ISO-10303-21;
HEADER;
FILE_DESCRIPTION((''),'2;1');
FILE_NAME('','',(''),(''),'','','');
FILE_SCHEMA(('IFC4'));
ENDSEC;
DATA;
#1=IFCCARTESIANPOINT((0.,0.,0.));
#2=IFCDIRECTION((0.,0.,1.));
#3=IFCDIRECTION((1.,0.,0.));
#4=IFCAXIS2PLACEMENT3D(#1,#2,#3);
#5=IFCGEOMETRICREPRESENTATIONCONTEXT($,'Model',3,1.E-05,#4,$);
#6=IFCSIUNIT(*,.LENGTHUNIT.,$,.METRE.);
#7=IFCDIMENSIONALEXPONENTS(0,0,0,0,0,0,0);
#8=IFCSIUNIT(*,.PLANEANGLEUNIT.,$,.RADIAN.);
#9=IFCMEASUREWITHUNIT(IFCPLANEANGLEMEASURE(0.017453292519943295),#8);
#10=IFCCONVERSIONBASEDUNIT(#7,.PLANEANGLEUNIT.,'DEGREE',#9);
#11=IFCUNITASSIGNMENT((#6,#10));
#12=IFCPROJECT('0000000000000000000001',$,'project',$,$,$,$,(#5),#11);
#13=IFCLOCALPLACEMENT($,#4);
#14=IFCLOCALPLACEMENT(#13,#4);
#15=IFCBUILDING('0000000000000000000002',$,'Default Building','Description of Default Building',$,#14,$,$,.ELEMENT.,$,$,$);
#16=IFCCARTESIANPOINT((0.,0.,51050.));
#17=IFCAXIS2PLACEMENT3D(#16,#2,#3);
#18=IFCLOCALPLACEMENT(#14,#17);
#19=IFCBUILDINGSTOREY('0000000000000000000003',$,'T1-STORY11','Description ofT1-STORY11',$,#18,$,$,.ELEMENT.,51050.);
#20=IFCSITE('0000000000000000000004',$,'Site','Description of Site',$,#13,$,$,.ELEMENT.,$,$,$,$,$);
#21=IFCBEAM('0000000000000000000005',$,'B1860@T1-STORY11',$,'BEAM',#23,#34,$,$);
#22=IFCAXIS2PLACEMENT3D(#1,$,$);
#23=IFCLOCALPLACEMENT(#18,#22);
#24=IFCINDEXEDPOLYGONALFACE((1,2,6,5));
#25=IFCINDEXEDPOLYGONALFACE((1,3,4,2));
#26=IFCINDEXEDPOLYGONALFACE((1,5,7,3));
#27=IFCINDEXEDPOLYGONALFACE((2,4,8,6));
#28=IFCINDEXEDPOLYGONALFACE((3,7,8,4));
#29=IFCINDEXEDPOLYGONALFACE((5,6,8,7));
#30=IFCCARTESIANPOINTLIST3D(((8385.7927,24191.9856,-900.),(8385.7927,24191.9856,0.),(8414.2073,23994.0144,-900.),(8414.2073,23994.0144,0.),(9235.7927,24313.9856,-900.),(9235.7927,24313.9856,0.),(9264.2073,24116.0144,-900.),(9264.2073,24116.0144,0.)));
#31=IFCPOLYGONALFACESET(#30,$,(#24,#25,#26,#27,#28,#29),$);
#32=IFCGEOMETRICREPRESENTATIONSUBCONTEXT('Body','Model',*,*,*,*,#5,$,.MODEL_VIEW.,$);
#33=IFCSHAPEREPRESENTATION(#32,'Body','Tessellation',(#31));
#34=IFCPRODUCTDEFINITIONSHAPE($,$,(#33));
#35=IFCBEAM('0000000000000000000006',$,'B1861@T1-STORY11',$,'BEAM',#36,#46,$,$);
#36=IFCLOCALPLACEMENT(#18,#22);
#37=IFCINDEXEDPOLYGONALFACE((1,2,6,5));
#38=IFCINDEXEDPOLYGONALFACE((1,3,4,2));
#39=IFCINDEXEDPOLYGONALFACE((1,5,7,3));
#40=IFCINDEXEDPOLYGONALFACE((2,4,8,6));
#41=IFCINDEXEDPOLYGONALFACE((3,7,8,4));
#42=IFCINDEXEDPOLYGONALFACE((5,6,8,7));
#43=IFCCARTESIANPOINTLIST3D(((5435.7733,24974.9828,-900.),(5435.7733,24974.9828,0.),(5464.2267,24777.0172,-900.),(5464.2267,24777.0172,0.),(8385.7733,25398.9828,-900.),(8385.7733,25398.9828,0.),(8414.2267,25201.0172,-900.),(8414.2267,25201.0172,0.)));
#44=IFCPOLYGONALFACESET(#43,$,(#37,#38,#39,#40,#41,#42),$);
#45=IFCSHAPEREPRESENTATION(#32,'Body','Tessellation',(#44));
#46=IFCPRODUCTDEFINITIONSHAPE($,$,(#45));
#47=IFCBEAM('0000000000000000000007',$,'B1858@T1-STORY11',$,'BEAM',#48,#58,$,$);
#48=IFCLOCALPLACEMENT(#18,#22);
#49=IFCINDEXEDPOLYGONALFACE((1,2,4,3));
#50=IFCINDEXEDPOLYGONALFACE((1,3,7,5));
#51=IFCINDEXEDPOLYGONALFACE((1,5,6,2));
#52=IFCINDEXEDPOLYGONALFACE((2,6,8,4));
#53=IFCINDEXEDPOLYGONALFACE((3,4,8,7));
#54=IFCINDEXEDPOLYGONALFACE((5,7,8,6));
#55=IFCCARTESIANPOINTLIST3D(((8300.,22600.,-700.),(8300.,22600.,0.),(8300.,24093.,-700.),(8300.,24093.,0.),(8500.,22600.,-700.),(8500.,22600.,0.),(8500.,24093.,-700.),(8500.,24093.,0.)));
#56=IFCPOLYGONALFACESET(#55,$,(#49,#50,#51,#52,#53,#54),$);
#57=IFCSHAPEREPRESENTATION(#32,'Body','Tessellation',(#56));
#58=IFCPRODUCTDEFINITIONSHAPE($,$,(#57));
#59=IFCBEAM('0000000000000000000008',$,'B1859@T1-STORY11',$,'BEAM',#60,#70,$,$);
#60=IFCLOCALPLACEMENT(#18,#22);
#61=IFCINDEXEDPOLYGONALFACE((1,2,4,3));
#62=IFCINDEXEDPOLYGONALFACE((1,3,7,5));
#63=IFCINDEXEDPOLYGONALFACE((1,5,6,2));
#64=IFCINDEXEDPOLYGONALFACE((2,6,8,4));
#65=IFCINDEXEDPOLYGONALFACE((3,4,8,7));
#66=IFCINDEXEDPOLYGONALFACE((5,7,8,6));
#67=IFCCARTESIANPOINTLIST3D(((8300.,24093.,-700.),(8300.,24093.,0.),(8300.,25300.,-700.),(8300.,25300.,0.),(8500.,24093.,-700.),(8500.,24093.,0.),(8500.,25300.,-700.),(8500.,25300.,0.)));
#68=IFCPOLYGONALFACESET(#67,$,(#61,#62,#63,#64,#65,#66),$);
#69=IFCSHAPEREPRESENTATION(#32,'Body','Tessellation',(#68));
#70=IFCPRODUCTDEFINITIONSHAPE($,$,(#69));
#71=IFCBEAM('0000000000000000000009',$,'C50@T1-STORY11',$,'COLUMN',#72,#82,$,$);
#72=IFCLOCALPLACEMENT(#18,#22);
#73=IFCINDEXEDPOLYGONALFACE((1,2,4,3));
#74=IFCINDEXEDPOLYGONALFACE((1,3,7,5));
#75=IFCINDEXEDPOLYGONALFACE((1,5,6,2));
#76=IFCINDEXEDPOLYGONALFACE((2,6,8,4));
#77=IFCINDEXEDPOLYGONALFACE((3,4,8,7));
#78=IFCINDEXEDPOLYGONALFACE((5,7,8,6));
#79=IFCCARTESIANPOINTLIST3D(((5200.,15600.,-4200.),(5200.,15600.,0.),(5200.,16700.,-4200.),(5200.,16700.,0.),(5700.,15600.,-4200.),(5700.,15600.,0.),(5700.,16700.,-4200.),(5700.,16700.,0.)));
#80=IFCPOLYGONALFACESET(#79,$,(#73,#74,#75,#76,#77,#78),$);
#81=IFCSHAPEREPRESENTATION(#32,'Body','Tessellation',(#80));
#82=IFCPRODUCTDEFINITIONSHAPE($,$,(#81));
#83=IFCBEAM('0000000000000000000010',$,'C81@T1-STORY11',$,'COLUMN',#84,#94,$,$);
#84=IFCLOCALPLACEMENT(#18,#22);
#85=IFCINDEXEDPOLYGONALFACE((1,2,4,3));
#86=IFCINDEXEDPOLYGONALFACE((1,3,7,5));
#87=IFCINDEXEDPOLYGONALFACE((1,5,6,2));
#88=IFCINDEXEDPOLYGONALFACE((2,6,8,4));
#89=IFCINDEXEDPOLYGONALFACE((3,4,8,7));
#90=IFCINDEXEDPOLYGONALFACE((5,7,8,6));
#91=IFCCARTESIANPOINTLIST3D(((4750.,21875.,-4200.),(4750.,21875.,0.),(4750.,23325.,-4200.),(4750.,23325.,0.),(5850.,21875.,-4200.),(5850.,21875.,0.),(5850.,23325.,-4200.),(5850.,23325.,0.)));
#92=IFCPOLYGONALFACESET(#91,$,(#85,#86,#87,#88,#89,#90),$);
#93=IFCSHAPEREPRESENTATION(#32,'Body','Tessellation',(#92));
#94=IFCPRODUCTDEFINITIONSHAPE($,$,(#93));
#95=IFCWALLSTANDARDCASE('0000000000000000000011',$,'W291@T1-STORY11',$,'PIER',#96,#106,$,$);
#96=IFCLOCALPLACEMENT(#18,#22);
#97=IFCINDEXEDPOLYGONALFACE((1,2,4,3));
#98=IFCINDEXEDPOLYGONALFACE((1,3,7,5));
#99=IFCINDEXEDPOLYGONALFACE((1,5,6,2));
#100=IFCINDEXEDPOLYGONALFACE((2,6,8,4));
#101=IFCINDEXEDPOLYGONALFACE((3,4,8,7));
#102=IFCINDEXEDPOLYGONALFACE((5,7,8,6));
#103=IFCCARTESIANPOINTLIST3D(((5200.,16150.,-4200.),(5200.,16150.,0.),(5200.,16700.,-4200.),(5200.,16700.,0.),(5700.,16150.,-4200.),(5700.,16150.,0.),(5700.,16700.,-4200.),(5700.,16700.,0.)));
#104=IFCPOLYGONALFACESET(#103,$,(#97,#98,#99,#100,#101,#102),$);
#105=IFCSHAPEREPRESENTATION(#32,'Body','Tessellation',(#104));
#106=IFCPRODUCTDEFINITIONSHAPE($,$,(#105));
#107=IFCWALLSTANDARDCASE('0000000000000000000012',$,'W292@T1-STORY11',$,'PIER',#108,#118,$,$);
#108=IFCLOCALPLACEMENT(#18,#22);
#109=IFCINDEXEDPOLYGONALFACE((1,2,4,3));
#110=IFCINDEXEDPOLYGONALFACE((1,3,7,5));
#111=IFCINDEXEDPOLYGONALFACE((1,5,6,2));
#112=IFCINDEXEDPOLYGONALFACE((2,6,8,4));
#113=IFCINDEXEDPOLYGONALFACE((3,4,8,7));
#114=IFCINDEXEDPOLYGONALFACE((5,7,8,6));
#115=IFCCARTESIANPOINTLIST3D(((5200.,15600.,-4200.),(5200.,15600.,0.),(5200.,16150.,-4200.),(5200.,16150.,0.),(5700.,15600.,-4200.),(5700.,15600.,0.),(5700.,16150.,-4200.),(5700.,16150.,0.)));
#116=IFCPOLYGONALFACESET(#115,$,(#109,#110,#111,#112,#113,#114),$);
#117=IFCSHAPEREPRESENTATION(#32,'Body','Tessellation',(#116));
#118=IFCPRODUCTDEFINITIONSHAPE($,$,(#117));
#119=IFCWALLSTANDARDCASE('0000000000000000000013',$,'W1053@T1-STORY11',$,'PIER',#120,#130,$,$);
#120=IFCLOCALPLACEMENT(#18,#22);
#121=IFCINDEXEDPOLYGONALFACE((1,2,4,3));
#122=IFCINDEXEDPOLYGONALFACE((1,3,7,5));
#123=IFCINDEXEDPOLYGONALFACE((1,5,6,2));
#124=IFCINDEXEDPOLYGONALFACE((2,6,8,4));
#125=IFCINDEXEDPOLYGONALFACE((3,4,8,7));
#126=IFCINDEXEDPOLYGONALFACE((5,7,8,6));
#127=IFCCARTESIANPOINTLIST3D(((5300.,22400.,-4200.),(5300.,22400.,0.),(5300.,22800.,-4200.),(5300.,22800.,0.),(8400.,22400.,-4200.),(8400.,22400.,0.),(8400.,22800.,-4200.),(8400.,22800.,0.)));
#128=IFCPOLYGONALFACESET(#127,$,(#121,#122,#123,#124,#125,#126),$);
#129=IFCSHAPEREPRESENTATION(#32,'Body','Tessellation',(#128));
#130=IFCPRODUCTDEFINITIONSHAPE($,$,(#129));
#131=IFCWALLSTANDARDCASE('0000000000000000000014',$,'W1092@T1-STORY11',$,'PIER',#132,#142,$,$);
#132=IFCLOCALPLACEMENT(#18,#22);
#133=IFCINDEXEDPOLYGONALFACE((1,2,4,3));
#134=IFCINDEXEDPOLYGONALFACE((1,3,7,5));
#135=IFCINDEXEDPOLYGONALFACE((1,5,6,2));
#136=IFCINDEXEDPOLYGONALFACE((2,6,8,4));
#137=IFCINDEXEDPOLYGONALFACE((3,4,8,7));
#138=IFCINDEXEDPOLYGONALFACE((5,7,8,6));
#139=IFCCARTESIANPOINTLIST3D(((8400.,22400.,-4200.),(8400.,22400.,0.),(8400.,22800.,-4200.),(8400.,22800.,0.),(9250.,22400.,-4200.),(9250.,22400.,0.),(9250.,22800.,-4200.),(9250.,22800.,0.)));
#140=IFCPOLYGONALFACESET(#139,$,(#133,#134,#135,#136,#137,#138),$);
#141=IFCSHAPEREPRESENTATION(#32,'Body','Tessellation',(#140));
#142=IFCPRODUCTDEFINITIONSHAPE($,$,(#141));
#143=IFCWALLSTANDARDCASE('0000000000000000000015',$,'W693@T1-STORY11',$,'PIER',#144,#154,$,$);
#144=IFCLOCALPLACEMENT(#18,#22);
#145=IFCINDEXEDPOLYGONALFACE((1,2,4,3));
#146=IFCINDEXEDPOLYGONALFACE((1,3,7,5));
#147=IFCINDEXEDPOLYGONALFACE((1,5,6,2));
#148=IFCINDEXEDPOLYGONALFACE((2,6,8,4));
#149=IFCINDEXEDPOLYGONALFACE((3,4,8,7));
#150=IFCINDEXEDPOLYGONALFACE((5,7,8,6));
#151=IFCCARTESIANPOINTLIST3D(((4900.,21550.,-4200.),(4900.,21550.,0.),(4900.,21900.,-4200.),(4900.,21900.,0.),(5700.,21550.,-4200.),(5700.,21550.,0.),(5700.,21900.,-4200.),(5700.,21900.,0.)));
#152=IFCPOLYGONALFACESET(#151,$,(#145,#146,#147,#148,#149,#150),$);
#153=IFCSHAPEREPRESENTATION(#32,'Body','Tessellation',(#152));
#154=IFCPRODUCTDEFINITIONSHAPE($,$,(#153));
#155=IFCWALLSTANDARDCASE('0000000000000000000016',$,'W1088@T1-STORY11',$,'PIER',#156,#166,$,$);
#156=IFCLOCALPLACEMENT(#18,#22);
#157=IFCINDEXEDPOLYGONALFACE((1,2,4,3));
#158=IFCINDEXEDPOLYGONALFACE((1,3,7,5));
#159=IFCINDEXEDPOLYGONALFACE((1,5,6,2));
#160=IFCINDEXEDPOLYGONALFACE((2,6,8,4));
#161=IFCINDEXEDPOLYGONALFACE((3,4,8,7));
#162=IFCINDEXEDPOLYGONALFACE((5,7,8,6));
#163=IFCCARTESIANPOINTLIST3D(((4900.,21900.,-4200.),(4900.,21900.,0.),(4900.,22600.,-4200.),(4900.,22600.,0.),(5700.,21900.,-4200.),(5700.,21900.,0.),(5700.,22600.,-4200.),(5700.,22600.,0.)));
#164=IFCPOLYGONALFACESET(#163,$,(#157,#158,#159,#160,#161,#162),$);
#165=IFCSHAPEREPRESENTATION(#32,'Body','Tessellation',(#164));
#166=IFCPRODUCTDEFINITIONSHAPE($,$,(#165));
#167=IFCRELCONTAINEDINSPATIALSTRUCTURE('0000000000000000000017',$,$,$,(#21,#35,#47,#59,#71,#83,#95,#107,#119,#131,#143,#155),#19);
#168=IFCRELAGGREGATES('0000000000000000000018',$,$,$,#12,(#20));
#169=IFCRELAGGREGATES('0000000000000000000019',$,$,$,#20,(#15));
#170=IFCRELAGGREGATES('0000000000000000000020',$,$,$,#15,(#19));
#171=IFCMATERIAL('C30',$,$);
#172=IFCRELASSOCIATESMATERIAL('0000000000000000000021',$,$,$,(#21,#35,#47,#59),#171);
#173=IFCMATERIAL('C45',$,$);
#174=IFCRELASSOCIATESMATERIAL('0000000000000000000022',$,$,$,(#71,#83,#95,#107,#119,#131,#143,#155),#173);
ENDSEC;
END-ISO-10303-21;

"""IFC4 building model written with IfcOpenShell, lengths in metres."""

from ifc_helpers import new_model, entity, si_unit, converted_unit, frame, origin_with_axes, place, context, subcontext, project, spatial, indexed_curve, rectangle, outline, extrude, material, element, save


model = new_model("IFC4")

# Units and contexts
model_context = context("Model", 3, precision=1e-05, world=origin_with_axes())
body_context = subcontext(model_context, "Body", "Model", "MODEL_VIEW")
ifc_project = project(units=[si_unit("LENGTHUNIT", "METRE"), converted_unit("PLANEANGLEUNIT", "DEGREE", entity("IfcPlaneAngleMeasure", 0.017453292519943295), si_unit("PLANEANGLEUNIT", "RADIAN"), dimensions=[0, 0, 0, 0, 0, 0, 0])], contexts=[model_context])

# Site, building, storey
site_placement = place(None, origin_with_axes())
site = spatial("IfcSite", under=ifc_project, at=site_placement, Name="Site", Description="Description of Site", CompositionType="ELEMENT")
building_placement = place(site_placement, origin_with_axes())
building = spatial("IfcBuilding", under=site, at=building_placement, Name="Default Building", Description="Description of Default Building", CompositionType="ELEMENT")
storey_placement = place(building_placement, frame((0.0, 0.0, 51050.0), z_axis=(0.0, 0.0, 1.0), x_axis=(1.0, 0.0, 0.0)))
storey = spatial("IfcBuildingStorey", under=building, at=storey_placement, Name="T1-STORY11", Description="Description ofT1-STORY11", CompositionType="ELEMENT", Elevation=51050.0)

# Beams
ifc_material_1 = material(Name="C30")
beam_1_placement = place(storey_placement, frame((8400.0, 24093.0, -450.0), z_axis=(0.989856, 0.142073, 0.0), x_axis=(-0.142073, 0.989856, 0.0)))
element("IfcBeam", 1, at=beam_1_placement, inside=storey, material=ifc_material_1, Name="B1860@T1-STORY11", ObjectType="BEAM", context=body_context, shape_type="SweptSolid", body=[
    extrude(rectangle(XDim=200.0, YDim=900.0), origin_with_axes(), (0.0, 0.0, 1.0), 858.7107),
])
beam_2_placement = place(storey_placement, frame((5450.0, 24876.0, -450.0), z_axis=(0.989828, 0.142267, 0.0), x_axis=(-0.142267, 0.989828, 0.0)))
element("IfcBeam", 2, at=beam_2_placement, inside=storey, material=ifc_material_1, Name="B1861@T1-STORY11", ObjectType="BEAM", context=body_context, shape_type="SweptSolid", body=[
    extrude(rectangle(XDim=200.0, YDim=900.0), origin_with_axes(), (0.0, 0.0, 1.0), 2980.3147),
])
beam_3_placement = place(storey_placement, frame((8400.0, 22600.0, -350.0), z_axis=(0.0, 1.0, 0.0), x_axis=(-1.0, 0.0, 0.0)))
element("IfcBeam", 3, at=beam_3_placement, inside=storey, material=ifc_material_1, Name="B1858@T1-STORY11", ObjectType="BEAM", context=body_context, shape_type="SweptSolid", body=[
    extrude(rectangle(XDim=200.0, YDim=700.0), origin_with_axes(), (0.0, 0.0, 1.0), 1493.0),
])
beam_4_placement = place(storey_placement, frame((8400.0, 24093.0, -350.0), z_axis=(0.0, 1.0, 0.0), x_axis=(-1.0, 0.0, 0.0)))
element("IfcBeam", 4, at=beam_4_placement, inside=storey, material=ifc_material_1, Name="B1859@T1-STORY11", ObjectType="BEAM", context=body_context, shape_type="SweptSolid", body=[
    extrude(rectangle(XDim=200.0, YDim=700.0), origin_with_axes(), (0.0, 0.0, 1.0), 1207.0),
])
ifc_material_2 = material(Name="C45")
beam_5_placement = place(storey_placement, frame((5450.0, 16150.0, -4200.0), z_axis=(0.0, 0.0, 1.0), x_axis=(-1.0, 0.0, 0.0)))
element("IfcBeam", 5, at=beam_5_placement, inside=storey, material=ifc_material_2, Name="C50@T1-STORY11", ObjectType="COLUMN", context=body_context, shape_type="SweptSolid", body=[
    extrude(rectangle(XDim=500.0, YDim=1100.0), origin_with_axes(), (0.0, 0.0, 1.0), 4200.0),
])
beam_6_placement = place(storey_placement, frame((5300.0, 22600.0, -4200.0), z_axis=(0.0, 0.0, 1.0), x_axis=(-1.0, 0.0, 0.0)))
element("IfcBeam", 6, at=beam_6_placement, inside=storey, material=ifc_material_2, Name="C81@T1-STORY11", ObjectType="COLUMN", context=body_context, shape_type="SweptSolid", body=[
    extrude(rectangle(XDim=1100.0, YDim=1450.0), origin_with_axes(), (0.0, 0.0, 1.0), 4200.0),
])

# Walls
for number, where, z_axis, x_axis, name in (
    (7, (5450.0, 16150.0, -4200.0), (0.0, 0.0, 1.0), (0.0, 1.0, 0.0), "W291@T1-STORY11"),
    (8, (5450.0, 15600.0, -4200.0), (0.0, 0.0, 1.0), (0.0, 1.0, 0.0), "W292@T1-STORY11"),
):
    element("IfcWallStandardCase", number, at=place(storey_placement, frame(where, z_axis=z_axis, x_axis=x_axis)), inside=storey, material=ifc_material_2, Name=name, ObjectType="PIER", context=body_context, shape_type="SweptSolid", body=[
        extrude(outline(indexed_curve([(0.0, -250.0), (0.0, 250.0), (550.0, 250.0), (550.0, -250.0), (0.0, -250.0)], self_intersect=False)), origin_with_axes(), (0.0, 0.0, 1.0), 4200.0),
    ])
wall_1_placement = place(storey_placement, frame((5300.0, 22600.0, -4200.0), z_axis=(0.0, 0.0, 1.0), x_axis=(1.0, 0.0, 0.0)))
element("IfcWallStandardCase", 9, at=wall_1_placement, inside=storey, material=ifc_material_2, Name="W1053@T1-STORY11", ObjectType="PIER", context=body_context, shape_type="SweptSolid", body=[
    extrude(outline(indexed_curve([(0.0, -200.0), (0.0, 200.0), (3100.0, 200.0), (3100.0, -200.0), (0.0, -200.0)], self_intersect=False)), origin_with_axes(), (0.0, 0.0, 1.0), 4200.0),
])
wall_2_placement = place(storey_placement, frame((8400.0, 22600.0, -4200.0), z_axis=(0.0, 0.0, 1.0), x_axis=(1.0, 0.0, 0.0)))
element("IfcWallStandardCase", 10, at=wall_2_placement, inside=storey, material=ifc_material_2, Name="W1092@T1-STORY11", ObjectType="PIER", context=body_context, shape_type="SweptSolid", body=[
    extrude(outline(indexed_curve([(0.0, -200.0), (0.0, 200.0), (850.0, 200.0), (850.0, -200.0), (0.0, -200.0)], self_intersect=False)), origin_with_axes(), (0.0, 0.0, 1.0), 4200.0),
])
wall_3_placement = place(storey_placement, frame((5300.0, 21550.0, -4200.0), z_axis=(0.0, 0.0, 1.0), x_axis=(0.0, 1.0, 0.0)))
element("IfcWallStandardCase", 11, at=wall_3_placement, inside=storey, material=ifc_material_2, Name="W693@T1-STORY11", ObjectType="PIER", context=body_context, shape_type="SweptSolid", body=[
    extrude(outline(indexed_curve([(0.0, -400.0), (0.0, 400.0), (350.0, 400.0), (350.0, -400.0), (0.0, -400.0)], self_intersect=False)), origin_with_axes(), (0.0, 0.0, 1.0), 4200.0),
])
wall_4_placement = place(storey_placement, frame((5300.0, 21900.0, -4200.0), z_axis=(0.0, 0.0, 1.0), x_axis=(0.0, 1.0, 0.0)))
element("IfcWallStandardCase", 12, at=wall_4_placement, inside=storey, material=ifc_material_2, Name="W1088@T1-STORY11", ObjectType="PIER", context=body_context, shape_type="SweptSolid", body=[
    extrude(outline(indexed_curve([(0.0, -400.0), (0.0, 400.0), (700.0, 400.0), (700.0, -400.0), (0.0, -400.0)], self_intersect=False)), origin_with_axes(), (0.0, 0.0, 1.0), 4200.0),
])

save(model, "model.ifc")
